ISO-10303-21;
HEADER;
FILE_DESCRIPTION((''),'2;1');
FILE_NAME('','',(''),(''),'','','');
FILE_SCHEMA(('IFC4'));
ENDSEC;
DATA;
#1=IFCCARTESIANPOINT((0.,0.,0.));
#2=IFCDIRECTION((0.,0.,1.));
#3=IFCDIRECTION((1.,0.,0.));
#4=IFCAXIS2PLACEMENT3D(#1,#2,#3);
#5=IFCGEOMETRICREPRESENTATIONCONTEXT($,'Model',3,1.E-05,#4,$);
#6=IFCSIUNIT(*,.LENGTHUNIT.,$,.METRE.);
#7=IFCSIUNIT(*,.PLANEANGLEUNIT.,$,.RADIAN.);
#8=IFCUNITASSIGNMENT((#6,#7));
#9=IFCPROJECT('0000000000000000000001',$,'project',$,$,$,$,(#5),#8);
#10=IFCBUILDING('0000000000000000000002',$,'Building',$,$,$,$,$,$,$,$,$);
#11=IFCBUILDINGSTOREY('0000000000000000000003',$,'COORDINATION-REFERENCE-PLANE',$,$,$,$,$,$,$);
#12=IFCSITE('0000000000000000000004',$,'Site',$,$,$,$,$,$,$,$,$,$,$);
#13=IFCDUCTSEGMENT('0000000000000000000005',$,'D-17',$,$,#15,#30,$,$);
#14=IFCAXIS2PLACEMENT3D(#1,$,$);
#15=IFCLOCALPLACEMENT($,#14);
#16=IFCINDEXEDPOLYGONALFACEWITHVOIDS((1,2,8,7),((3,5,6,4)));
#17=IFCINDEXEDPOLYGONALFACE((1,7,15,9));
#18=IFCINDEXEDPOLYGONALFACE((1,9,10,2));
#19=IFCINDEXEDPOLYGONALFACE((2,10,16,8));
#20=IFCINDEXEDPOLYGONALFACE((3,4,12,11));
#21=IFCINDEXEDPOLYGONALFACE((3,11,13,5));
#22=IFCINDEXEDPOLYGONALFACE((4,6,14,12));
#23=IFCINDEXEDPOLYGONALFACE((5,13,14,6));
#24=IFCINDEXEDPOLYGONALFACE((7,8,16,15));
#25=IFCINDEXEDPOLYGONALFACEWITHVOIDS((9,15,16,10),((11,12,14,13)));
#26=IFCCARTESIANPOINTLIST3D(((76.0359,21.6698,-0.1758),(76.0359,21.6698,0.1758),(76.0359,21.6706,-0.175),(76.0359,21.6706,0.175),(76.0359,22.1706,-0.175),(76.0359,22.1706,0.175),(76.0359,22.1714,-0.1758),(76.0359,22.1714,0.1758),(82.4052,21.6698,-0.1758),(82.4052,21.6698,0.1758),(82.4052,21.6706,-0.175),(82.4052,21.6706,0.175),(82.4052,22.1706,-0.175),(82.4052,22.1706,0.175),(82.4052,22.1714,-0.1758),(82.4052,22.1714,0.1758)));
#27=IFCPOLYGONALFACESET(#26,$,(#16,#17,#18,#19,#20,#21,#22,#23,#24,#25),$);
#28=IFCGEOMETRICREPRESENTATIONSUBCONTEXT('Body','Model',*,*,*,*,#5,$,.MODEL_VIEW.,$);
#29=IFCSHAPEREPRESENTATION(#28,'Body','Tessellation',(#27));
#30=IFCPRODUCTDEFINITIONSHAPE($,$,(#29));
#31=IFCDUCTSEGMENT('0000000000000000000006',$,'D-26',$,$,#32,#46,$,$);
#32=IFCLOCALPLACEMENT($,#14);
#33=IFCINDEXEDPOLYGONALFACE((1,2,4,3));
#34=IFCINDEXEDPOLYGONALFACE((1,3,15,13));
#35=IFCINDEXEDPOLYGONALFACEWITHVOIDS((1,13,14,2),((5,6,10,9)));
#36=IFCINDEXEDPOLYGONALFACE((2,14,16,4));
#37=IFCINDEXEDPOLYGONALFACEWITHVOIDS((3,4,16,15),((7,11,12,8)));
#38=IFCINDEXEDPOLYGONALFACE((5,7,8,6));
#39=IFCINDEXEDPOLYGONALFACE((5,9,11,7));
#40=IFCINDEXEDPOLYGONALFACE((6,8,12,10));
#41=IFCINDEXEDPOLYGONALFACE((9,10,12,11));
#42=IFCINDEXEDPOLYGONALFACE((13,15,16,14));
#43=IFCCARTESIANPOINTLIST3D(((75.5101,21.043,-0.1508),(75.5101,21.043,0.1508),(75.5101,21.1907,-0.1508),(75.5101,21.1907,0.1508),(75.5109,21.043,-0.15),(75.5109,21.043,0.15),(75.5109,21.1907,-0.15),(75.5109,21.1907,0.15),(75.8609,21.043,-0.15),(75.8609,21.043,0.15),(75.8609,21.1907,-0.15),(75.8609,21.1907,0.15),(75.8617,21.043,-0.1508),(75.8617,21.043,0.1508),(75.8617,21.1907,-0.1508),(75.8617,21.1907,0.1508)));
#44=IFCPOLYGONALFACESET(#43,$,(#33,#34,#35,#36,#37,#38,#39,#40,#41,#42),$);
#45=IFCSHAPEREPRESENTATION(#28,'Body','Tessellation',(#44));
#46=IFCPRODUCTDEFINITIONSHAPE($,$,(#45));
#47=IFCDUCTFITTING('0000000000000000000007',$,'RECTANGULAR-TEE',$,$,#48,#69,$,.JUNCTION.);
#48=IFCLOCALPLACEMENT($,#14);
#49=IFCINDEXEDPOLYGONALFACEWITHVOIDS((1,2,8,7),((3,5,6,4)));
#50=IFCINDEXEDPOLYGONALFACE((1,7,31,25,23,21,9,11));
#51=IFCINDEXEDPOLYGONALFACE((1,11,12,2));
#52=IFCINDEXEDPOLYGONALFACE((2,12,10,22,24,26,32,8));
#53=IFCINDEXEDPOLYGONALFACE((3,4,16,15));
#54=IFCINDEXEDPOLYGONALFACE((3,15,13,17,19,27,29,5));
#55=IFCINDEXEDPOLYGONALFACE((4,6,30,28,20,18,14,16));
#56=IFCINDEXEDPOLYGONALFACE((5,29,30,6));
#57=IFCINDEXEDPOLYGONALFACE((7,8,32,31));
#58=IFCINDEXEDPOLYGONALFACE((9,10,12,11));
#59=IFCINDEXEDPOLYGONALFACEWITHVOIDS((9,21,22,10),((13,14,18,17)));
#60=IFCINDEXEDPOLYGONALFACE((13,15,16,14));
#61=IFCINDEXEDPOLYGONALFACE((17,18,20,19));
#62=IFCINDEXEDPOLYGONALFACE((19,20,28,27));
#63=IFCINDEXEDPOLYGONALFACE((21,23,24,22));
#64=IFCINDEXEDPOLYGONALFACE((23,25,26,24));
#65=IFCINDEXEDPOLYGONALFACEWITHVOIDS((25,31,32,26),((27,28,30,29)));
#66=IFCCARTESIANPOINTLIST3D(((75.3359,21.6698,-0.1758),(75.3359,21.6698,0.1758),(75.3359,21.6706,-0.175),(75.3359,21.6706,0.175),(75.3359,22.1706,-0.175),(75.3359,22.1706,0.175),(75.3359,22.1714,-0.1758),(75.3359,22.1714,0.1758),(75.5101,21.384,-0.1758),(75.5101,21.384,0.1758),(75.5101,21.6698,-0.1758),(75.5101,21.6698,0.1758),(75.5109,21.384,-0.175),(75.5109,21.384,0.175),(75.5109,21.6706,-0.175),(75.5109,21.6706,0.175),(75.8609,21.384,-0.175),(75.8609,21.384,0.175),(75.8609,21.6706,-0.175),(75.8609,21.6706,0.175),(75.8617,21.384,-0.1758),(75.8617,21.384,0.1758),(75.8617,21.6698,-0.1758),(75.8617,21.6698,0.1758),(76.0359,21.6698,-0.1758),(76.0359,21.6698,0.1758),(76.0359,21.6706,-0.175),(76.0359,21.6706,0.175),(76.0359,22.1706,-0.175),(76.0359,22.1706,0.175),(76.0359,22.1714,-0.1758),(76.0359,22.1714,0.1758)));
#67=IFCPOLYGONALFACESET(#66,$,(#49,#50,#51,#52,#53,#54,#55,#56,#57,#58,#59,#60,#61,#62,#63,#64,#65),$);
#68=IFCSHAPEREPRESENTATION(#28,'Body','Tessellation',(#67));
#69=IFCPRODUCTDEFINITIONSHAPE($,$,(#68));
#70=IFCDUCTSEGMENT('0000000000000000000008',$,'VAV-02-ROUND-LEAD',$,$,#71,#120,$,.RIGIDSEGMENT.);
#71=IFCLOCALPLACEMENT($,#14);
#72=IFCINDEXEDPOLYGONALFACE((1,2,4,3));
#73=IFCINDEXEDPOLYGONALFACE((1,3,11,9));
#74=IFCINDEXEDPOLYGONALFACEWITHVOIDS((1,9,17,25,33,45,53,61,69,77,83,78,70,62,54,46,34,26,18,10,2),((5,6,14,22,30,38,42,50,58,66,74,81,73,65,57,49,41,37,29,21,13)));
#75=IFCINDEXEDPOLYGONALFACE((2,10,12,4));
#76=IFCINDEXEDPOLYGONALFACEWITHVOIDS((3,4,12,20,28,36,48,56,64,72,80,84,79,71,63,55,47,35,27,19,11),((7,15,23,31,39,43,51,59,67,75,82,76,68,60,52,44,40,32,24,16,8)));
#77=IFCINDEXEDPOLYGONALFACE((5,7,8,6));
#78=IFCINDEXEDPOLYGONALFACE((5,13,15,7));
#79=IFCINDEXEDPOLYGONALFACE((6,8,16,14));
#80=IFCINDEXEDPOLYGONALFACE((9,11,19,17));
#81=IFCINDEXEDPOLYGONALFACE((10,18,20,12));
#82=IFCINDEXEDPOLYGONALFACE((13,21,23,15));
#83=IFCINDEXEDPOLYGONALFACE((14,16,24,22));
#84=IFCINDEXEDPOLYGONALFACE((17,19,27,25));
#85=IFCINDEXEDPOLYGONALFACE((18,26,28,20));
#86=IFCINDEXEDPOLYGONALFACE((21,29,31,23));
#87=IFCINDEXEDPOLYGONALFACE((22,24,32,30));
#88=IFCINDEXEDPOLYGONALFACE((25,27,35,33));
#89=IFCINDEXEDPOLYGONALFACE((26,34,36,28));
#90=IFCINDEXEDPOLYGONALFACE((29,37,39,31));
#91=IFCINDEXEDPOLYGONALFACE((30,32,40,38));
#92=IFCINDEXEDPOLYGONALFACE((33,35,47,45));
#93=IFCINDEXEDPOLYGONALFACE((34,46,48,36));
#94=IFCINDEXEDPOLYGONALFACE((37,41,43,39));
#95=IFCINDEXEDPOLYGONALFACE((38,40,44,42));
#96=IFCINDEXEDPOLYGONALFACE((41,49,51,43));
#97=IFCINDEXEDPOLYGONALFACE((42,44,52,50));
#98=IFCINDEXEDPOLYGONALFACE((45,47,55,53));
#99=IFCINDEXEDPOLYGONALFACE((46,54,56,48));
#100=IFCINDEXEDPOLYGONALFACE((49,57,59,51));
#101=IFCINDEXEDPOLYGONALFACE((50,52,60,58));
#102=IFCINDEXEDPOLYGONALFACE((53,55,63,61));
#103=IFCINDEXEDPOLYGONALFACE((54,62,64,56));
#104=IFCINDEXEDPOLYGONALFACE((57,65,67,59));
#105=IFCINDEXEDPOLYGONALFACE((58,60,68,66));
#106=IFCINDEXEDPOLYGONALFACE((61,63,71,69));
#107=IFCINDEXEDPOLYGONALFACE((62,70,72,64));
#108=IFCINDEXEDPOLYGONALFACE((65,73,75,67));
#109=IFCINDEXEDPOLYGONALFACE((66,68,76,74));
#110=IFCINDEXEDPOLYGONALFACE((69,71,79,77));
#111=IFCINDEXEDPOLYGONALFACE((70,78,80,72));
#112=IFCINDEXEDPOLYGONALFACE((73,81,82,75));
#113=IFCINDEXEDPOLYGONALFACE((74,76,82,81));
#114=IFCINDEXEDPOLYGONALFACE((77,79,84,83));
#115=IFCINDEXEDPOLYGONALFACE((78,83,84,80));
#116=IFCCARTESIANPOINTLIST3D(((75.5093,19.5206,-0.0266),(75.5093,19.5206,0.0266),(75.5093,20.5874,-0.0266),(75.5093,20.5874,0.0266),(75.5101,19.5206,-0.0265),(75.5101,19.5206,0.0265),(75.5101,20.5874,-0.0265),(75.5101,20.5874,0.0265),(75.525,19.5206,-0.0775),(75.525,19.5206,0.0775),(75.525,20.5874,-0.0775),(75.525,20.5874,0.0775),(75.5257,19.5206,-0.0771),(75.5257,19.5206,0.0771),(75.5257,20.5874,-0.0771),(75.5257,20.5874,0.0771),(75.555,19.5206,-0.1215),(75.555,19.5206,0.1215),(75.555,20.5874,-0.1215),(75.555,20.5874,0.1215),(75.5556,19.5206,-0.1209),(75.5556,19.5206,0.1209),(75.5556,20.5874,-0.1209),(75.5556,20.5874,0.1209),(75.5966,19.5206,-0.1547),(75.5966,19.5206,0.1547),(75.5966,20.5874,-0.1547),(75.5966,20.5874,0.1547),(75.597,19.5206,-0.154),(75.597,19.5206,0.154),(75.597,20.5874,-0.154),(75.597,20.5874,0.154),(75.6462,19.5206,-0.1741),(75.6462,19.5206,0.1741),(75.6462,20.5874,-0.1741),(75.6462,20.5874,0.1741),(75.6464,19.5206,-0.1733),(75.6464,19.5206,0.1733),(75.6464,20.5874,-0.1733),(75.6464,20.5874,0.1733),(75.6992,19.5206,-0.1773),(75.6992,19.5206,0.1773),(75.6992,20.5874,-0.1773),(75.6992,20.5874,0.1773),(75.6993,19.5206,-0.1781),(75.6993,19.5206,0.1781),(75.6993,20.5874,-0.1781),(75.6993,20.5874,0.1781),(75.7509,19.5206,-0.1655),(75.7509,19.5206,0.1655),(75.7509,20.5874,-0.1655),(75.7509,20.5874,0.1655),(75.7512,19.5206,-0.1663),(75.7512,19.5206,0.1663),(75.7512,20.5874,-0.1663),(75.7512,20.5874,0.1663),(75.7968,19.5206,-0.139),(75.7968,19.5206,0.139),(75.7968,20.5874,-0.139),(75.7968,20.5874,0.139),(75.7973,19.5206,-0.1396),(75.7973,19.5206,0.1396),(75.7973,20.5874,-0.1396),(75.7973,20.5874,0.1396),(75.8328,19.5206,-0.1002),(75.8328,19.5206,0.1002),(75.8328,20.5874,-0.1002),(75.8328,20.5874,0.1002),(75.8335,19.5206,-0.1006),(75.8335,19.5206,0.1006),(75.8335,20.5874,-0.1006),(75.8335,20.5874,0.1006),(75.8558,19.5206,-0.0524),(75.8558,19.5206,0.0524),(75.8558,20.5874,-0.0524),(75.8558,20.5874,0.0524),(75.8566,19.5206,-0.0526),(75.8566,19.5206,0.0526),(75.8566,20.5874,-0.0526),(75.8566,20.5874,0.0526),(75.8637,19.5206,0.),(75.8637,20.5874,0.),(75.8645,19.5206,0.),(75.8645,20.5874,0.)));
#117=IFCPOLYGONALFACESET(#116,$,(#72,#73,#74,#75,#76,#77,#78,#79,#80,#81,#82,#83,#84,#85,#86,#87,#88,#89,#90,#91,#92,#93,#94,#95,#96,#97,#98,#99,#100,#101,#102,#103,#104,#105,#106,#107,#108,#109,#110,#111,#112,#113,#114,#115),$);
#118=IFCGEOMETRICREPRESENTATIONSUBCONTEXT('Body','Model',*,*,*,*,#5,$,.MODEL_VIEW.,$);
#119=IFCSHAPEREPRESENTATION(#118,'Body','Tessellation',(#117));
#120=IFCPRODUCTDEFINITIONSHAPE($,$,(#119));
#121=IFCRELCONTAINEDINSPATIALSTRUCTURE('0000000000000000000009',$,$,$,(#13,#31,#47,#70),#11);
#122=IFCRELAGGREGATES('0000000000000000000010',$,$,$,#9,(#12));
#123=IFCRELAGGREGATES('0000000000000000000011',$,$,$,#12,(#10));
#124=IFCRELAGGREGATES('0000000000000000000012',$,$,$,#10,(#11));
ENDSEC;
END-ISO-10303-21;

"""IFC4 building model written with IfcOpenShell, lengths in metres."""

from ifc_helpers import new_model, si_unit, frame, origin, origin_with_axes, place, context, subcontext, project, spatial, rectangle, hollow_rectangle, hollow_circle, extrude, boolean, element, save


model = new_model("IFC4")

# Units and contexts
model_context = context("Model", 3, precision=1e-05, world=origin_with_axes())
body_context_1 = subcontext(model_context, "Body", "Model", "MODEL_VIEW")
body_context_2 = subcontext(model_context, "Body", "Model", "MODEL_VIEW")
ifc_project = project(units=[si_unit("LENGTHUNIT", "METRE"), si_unit("PLANEANGLEUNIT", "RADIAN")], contexts=[model_context])

# Site, building, storey
site = spatial("IfcSite", under=ifc_project, Name="Site")
building = spatial("IfcBuilding", under=site, Name="Building")
storey = spatial("IfcBuildingStorey", under=building, Name="COORDINATION-REFERENCE-PLANE")

# Duct segments
duct_segment_1_placement = place(None, frame((76.0359, 21.9206, 0.0), z_axis=(1.0, 0.0, 0.0), x_axis=(0.0, 1.0, 0.0)))
element("IfcDuctSegment", 1, at=duct_segment_1_placement, inside=storey, Name="D-17", context=body_context_1, shape_type="SweptSolid", body=[
    extrude(hollow_rectangle(XDim=0.5016, YDim=0.3516, WallThickness=0.0008), origin(), (0.0, 0.0, 1.0), 6.3693),
])
duct_segment_2_placement = place(None, frame((75.6859, 21.043, 0.0), z_axis=(0.0, 1.0, 0.0), x_axis=(1.0, 0.0, 0.0)))
element("IfcDuctSegment", 2, at=duct_segment_2_placement, inside=storey, Name="D-26", context=body_context_1, shape_type="SweptSolid", body=[
    extrude(hollow_rectangle(XDim=0.3516, YDim=0.3016, WallThickness=0.0008), origin(), (0.0, 0.0, 1.0), 0.1477),
])

# Duct fitting
duct_fitting_1_placement = place(None, frame((75.6859, 21.9206, 0.0), z_axis=(-1.0, 0.0, 0.0), x_axis=(0.0, -1.0, 0.0)))
solid_1 = boolean("UNION", extrude(rectangle(XDim=0.5, YDim=0.35), frame((0.0, 0.0, -0.35), z_axis=(0.0, 0.0, 1.0), x_axis=(1.0, 0.0, 0.0)), (0.0, 0.0, 1.0), 0.7), extrude(rectangle(XDim=0.35, YDim=0.35), frame((0.0, 0.0, 0.0), z_axis=(1.0, 0.0, 0.0), x_axis=(0.0, 0.0, -1.0)), (0.0, 0.0, 1.0), 0.5366))
element("IfcDuctFitting", 3, at=duct_fitting_1_placement, inside=storey, Name="RECTANGULAR-TEE", PredefinedType="JUNCTION", context=body_context_1, shape_type="CSG", body=[
    boolean("DIFFERENCE", boolean("UNION", extrude(rectangle(XDim=0.5016, YDim=0.3516), frame((0.0, 0.0, -0.35), z_axis=(0.0, 0.0, 1.0), x_axis=(1.0, 0.0, 0.0)), (0.0, 0.0, 1.0), 0.7), extrude(rectangle(XDim=0.3516, YDim=0.3516), frame((0.0, 0.0, 0.0), z_axis=(1.0, 0.0, 0.0), x_axis=(0.0, 0.0, -1.0)), (0.0, 0.0, 1.0), 0.5366)), solid_1),
])

# Duct segment
duct_segment_3_placement = place(None, frame((75.6859, 20.5874, 0.0), z_axis=(0.0, -1.0, 0.0), x_axis=(1.0, 0.0, 0.0)))
element("IfcDuctSegment", 4, at=duct_segment_3_placement, inside=storey, Name="VAV-02-ROUND-LEAD", PredefinedType="RIGIDSEGMENT", context=body_context_2, shape_type="SweptSolid", body=[
    extrude(hollow_circle(Radius=0.1786, WallThickness=0.0008), origin(), (0.0, 0.0, 1.0), 1.0668),
])

save(model, "model.ifc")
